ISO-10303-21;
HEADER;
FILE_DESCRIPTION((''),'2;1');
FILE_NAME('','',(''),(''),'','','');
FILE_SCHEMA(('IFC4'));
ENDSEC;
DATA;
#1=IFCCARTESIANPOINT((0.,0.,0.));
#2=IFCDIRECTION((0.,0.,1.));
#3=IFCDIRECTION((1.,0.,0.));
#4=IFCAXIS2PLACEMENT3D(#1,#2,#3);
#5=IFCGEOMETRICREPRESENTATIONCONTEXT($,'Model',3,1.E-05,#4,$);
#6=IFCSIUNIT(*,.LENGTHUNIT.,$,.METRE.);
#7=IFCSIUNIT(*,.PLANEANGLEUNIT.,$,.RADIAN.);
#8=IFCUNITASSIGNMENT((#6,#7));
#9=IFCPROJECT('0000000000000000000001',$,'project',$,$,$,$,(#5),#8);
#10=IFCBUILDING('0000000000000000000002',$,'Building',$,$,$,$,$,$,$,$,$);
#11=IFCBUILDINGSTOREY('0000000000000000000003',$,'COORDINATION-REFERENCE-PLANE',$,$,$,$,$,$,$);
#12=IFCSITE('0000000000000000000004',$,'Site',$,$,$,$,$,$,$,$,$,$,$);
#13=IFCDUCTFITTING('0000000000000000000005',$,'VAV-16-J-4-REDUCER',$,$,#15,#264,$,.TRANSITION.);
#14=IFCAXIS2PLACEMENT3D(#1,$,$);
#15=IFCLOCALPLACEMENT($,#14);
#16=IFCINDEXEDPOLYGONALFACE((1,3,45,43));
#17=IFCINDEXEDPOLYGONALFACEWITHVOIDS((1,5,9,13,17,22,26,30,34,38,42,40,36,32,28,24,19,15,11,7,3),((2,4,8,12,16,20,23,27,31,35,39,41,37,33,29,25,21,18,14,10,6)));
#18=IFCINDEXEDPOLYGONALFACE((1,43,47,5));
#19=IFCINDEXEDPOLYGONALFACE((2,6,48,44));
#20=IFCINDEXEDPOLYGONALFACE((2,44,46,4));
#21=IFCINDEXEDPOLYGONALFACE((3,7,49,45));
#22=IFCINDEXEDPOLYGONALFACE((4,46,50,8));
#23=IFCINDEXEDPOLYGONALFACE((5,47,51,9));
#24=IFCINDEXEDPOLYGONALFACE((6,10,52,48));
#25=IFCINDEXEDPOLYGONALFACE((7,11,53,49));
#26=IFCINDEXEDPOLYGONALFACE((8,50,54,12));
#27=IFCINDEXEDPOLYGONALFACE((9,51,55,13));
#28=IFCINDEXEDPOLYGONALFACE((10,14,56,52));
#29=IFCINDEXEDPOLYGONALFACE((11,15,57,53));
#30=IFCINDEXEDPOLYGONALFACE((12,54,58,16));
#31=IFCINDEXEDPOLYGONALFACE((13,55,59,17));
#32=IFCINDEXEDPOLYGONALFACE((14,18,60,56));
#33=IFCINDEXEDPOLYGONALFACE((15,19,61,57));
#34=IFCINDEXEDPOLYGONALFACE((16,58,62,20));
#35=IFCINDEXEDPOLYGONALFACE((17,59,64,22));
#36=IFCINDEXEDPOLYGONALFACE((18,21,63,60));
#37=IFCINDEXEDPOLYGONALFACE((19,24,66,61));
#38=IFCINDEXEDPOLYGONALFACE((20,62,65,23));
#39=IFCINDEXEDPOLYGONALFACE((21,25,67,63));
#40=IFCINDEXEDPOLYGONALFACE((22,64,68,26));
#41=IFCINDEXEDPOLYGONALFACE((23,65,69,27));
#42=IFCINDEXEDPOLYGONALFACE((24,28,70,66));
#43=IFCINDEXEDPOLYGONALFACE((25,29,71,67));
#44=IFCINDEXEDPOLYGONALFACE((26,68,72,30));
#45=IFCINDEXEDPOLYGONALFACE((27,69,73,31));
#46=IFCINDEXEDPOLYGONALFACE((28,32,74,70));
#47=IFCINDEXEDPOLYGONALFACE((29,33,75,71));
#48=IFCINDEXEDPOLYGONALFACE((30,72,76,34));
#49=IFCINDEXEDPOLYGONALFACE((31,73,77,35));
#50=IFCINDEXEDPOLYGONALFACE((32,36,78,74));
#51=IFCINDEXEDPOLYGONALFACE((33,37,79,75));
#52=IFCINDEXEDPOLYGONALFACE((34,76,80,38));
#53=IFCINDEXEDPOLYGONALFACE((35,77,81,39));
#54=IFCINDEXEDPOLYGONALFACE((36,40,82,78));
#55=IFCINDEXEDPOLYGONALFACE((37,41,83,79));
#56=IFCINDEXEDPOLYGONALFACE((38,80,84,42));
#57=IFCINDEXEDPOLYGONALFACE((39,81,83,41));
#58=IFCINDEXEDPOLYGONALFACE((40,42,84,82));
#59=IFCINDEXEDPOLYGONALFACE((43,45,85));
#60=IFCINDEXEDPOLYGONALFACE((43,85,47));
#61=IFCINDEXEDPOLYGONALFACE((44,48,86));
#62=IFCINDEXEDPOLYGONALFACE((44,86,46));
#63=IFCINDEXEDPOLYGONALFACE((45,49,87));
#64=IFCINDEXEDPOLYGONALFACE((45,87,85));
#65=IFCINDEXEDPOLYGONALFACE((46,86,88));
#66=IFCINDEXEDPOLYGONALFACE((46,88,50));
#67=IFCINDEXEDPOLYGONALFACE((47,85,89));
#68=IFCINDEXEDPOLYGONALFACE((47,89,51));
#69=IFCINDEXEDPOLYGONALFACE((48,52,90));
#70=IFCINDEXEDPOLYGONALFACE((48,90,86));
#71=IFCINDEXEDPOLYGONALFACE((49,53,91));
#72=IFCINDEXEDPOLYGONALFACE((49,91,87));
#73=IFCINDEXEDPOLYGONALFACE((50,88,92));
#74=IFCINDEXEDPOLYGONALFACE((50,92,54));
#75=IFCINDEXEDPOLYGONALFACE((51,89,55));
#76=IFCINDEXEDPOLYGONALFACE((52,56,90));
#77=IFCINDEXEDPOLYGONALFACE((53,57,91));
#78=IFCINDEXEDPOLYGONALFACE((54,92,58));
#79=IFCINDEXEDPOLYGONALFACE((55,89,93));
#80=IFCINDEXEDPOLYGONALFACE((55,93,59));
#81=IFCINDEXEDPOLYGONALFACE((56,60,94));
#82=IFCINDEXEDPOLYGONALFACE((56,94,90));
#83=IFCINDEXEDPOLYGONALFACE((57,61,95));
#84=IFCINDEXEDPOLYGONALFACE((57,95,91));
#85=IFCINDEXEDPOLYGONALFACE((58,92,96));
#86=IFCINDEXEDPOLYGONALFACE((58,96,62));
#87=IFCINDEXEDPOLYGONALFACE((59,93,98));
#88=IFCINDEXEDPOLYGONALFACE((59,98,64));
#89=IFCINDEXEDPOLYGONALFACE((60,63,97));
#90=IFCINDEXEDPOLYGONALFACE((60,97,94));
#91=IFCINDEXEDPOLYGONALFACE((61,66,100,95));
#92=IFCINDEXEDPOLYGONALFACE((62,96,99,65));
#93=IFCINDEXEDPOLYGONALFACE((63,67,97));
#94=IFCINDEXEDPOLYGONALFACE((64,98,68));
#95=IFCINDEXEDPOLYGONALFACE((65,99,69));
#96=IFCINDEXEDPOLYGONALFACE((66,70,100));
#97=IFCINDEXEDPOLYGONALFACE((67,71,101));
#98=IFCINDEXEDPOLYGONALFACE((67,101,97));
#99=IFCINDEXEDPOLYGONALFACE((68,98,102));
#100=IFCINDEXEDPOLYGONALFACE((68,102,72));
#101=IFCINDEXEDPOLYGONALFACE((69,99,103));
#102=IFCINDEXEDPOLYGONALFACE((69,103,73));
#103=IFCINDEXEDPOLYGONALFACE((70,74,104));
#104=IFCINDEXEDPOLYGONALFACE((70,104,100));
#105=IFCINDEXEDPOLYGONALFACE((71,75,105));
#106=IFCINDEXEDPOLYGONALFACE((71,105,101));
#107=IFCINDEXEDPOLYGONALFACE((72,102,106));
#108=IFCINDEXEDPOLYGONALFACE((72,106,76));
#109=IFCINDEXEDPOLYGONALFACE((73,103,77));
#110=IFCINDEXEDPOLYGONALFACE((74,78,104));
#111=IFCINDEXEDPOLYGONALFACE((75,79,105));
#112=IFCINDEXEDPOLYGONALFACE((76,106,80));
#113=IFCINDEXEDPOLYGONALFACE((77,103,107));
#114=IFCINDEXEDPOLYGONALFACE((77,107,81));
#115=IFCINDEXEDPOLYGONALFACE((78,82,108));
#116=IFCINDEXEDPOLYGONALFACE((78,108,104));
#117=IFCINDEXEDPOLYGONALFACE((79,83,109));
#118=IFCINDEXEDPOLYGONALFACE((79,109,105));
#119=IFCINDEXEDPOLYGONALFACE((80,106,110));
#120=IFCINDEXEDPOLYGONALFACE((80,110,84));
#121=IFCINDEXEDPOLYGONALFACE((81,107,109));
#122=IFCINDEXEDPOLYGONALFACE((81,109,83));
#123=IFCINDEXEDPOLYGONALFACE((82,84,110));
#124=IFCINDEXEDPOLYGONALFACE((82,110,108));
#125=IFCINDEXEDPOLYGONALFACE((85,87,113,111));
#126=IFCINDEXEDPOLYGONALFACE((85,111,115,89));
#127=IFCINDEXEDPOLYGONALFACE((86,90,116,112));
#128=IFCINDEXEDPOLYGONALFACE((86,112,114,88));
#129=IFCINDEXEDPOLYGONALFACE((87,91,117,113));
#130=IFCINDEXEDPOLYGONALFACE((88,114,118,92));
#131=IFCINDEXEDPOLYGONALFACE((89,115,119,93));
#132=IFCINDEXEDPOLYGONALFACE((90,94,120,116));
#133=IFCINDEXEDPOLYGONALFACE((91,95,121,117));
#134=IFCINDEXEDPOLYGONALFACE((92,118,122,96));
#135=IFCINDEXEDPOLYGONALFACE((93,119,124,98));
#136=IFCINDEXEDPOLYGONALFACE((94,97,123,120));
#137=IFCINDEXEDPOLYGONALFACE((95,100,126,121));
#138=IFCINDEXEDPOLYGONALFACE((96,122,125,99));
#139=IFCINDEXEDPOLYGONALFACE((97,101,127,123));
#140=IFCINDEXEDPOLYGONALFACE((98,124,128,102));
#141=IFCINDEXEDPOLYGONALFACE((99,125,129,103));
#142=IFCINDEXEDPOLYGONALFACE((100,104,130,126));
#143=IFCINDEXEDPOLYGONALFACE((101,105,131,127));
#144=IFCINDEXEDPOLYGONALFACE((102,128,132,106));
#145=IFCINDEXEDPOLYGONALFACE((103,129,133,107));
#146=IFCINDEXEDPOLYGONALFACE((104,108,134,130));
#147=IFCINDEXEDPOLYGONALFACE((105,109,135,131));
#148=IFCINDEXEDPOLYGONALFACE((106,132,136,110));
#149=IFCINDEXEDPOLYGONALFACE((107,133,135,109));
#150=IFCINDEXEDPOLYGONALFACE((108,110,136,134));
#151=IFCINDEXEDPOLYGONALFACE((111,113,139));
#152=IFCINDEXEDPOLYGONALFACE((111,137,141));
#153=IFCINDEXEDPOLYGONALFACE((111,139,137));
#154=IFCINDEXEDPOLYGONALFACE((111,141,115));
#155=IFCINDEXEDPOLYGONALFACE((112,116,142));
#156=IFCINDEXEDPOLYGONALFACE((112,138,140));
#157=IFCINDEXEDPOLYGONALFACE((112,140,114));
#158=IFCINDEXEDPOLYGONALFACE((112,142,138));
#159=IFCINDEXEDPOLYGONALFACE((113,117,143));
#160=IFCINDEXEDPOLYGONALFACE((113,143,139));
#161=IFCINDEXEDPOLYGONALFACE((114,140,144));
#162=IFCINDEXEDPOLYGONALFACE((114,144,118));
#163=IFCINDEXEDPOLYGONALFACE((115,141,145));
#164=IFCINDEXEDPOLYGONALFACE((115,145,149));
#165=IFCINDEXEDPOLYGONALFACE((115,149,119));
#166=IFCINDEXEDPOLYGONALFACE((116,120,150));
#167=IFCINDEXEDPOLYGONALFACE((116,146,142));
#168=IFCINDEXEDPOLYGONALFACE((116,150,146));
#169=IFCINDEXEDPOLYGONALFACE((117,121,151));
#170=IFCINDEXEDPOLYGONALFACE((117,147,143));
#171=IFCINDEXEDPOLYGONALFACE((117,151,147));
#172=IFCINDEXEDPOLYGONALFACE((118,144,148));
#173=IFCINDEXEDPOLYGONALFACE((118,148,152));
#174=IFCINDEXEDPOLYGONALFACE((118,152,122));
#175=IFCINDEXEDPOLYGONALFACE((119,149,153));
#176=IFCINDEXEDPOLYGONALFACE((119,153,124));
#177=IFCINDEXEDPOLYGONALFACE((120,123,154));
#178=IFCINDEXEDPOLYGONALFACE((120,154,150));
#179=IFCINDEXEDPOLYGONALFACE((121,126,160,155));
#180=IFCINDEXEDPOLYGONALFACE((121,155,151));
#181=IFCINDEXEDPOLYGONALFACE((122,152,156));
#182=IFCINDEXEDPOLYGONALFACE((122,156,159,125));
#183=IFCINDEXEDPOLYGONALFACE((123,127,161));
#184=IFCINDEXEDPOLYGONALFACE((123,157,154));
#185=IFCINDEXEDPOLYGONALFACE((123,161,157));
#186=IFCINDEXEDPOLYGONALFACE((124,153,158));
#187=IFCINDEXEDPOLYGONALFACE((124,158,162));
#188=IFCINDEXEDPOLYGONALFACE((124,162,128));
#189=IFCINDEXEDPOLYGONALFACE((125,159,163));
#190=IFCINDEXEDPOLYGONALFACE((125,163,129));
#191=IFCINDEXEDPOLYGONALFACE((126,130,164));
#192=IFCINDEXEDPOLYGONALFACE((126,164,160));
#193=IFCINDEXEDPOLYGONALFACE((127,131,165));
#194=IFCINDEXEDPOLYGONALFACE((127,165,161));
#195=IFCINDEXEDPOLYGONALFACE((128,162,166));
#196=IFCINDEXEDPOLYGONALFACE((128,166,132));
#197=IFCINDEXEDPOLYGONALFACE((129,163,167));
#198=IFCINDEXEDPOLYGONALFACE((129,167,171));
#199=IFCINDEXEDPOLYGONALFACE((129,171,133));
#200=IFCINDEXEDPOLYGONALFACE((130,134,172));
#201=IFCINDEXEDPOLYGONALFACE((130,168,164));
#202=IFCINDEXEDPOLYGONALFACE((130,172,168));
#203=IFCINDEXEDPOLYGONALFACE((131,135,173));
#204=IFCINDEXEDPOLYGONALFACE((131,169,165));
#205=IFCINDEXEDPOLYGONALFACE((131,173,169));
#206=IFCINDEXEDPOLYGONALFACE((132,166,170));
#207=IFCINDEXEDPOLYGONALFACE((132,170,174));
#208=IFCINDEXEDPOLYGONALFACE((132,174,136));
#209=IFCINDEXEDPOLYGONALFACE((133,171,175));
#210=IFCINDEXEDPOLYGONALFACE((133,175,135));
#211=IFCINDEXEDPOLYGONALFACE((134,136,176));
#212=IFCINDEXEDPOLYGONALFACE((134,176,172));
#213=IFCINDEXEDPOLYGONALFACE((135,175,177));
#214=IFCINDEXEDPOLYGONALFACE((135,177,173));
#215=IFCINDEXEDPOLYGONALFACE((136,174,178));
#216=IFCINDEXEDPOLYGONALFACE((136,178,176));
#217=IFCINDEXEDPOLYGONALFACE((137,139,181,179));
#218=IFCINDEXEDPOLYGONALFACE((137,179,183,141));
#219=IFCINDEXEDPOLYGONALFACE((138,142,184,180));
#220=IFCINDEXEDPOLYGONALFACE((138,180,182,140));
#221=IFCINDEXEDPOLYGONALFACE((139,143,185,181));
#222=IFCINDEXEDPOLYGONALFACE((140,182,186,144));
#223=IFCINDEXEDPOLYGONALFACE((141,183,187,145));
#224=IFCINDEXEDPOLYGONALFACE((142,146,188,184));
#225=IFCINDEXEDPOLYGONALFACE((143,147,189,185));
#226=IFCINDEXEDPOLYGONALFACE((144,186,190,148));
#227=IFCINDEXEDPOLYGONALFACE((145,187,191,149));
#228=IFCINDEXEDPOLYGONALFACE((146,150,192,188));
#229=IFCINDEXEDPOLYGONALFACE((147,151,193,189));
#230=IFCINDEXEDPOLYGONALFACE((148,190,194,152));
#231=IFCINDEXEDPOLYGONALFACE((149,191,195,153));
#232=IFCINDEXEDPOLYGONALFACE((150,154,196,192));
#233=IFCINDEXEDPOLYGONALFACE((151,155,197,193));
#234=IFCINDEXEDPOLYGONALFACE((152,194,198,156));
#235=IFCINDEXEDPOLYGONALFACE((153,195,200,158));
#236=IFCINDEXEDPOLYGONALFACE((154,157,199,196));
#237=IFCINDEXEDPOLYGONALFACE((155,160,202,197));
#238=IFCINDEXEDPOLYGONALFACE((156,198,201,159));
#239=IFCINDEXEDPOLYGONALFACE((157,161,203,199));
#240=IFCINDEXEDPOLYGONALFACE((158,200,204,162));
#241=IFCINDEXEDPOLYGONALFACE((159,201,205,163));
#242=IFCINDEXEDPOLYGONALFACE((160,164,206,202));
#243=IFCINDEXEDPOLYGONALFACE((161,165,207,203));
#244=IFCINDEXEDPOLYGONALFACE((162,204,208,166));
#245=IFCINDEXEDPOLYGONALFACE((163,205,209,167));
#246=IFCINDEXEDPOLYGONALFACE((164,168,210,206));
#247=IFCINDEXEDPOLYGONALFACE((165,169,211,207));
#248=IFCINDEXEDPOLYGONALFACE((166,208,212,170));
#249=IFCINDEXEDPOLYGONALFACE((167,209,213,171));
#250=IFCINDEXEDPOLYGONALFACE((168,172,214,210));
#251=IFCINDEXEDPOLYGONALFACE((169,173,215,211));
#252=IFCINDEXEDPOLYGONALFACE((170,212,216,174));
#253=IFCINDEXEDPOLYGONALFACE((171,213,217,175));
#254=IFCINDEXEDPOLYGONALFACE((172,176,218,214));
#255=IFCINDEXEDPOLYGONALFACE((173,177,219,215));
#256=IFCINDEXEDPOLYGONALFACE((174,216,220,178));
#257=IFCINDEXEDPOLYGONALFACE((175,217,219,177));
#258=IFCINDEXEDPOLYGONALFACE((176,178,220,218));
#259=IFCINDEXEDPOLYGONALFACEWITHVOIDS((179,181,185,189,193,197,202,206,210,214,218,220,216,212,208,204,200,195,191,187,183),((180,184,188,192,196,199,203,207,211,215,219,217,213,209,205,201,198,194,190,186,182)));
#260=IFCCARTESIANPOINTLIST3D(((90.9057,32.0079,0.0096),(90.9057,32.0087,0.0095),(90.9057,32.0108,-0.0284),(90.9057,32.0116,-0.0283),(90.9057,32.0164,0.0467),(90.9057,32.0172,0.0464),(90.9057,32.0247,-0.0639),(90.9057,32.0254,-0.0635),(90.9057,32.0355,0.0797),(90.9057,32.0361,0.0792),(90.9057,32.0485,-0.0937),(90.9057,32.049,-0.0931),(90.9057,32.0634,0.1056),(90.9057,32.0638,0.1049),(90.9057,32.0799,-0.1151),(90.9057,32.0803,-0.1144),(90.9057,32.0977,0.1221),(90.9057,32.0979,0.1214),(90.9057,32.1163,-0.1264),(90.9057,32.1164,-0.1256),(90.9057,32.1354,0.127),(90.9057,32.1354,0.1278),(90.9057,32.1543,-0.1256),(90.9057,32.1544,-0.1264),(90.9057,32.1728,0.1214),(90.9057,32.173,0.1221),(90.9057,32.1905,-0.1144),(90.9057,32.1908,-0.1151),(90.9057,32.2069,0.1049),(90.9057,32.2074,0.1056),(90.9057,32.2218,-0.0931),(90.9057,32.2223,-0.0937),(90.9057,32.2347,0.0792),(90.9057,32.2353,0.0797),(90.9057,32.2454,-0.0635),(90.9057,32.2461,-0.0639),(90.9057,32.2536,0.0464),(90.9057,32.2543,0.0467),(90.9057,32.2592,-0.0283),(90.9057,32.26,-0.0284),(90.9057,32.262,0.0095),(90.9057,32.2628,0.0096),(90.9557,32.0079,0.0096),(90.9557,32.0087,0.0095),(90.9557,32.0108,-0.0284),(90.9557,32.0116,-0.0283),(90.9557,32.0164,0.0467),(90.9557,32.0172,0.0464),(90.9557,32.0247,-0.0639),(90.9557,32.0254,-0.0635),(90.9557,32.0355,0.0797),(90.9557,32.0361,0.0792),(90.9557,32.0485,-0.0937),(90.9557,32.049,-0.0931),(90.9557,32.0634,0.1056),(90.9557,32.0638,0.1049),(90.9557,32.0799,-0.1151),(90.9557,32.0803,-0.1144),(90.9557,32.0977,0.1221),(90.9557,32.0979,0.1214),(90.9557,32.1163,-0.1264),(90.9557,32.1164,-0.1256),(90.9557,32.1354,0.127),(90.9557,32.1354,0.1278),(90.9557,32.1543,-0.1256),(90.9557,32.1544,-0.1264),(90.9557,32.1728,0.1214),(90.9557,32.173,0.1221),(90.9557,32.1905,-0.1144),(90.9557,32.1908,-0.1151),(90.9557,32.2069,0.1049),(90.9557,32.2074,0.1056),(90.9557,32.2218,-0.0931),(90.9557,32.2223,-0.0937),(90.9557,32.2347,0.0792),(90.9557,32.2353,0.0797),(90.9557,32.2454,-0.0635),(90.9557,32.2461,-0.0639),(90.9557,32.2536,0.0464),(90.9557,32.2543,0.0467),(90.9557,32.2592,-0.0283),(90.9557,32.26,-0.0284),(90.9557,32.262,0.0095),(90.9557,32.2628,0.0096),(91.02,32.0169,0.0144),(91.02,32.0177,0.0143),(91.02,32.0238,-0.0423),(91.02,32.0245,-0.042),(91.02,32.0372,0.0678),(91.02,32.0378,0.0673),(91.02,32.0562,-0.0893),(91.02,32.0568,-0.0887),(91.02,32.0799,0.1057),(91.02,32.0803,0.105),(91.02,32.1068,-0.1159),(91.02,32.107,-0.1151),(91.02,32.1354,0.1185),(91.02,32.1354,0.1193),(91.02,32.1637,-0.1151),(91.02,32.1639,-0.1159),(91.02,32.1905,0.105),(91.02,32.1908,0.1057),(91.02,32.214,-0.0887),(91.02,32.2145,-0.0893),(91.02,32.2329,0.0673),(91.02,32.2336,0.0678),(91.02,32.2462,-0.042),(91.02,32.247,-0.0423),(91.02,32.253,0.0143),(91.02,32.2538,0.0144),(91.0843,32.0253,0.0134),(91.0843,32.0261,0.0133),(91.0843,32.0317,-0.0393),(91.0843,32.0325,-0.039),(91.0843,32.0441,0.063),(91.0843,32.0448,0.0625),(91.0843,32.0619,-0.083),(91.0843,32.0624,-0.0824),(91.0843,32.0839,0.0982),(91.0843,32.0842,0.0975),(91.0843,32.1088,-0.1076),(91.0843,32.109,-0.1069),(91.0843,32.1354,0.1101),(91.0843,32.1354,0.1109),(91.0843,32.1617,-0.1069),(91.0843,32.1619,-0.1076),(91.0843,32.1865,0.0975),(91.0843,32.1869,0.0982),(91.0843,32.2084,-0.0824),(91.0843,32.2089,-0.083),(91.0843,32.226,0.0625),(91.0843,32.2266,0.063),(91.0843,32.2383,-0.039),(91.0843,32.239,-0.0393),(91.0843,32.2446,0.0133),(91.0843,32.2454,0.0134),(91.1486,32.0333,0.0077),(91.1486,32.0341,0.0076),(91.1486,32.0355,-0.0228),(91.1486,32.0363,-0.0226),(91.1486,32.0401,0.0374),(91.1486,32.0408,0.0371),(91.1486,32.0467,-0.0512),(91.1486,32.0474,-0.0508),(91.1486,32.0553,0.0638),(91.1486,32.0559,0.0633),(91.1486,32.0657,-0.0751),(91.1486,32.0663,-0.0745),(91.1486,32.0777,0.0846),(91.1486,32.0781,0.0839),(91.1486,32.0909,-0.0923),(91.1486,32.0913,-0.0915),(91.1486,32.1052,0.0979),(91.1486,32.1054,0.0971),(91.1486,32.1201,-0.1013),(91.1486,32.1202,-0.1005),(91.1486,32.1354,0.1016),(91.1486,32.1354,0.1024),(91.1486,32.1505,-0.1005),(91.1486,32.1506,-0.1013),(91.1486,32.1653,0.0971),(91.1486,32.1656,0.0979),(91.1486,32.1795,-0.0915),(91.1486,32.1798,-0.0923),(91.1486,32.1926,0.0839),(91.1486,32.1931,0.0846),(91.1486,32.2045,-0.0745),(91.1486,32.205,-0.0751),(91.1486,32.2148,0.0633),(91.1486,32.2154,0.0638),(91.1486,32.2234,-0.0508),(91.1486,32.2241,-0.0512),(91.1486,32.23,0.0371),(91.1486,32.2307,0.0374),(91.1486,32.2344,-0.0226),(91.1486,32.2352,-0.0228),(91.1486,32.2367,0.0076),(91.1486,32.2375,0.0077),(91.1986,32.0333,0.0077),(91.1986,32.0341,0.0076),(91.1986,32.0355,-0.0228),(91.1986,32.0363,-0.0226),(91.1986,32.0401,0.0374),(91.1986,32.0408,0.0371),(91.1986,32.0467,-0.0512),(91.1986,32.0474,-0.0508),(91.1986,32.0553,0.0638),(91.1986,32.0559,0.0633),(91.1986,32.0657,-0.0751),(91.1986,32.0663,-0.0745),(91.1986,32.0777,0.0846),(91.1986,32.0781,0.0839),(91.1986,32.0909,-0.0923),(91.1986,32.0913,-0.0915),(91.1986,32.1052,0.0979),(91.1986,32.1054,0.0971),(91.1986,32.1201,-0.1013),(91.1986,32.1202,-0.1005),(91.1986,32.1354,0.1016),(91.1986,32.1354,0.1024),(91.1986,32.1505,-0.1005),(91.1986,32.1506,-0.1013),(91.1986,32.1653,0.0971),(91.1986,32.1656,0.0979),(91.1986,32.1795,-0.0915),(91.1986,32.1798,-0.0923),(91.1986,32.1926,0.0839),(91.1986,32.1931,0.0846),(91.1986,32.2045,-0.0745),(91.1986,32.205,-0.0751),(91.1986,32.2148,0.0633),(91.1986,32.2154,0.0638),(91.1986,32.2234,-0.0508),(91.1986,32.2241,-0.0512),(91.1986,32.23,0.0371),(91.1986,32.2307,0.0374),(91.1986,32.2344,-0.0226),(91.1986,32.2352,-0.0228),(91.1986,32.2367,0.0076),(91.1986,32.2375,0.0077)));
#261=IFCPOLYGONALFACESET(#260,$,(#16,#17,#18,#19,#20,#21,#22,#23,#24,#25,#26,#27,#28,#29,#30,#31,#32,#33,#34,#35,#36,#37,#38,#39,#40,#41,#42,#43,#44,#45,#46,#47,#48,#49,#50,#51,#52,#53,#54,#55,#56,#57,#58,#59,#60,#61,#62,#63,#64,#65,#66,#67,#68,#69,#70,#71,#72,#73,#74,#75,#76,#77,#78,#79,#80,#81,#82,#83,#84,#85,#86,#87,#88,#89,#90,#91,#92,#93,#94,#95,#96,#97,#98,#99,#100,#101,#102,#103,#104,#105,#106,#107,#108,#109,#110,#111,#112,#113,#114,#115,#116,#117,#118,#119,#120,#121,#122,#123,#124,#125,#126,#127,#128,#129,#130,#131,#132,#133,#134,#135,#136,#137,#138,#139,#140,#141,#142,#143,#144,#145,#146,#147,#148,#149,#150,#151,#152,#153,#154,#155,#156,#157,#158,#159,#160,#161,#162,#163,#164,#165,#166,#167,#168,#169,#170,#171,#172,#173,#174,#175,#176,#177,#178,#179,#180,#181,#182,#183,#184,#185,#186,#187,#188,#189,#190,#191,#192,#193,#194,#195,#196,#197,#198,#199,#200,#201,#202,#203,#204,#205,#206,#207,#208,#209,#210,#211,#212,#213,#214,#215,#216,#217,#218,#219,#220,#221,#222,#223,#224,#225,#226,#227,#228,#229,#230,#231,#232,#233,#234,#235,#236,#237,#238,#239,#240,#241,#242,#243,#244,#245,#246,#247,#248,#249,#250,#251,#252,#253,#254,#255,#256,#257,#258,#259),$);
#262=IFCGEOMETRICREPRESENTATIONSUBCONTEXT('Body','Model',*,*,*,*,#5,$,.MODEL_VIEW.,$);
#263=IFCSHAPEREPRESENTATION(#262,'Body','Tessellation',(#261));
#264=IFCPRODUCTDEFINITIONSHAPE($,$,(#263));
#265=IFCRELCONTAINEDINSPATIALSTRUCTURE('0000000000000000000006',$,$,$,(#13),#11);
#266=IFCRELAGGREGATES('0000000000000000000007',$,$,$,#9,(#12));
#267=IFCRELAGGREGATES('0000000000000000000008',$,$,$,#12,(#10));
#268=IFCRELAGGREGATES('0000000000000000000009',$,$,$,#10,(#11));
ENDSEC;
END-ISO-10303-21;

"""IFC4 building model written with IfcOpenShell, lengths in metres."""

from ifc_helpers import new_model, entity, si_unit, frame, origin_with_axes, place, context, subcontext, project, spatial, element, save


model = new_model("IFC4")

# Units and contexts
model_context = context("Model", 3, precision=1e-05, world=origin_with_axes())
body_context_1 = subcontext(model_context, "Body", "Model", "MODEL_VIEW")
ifc_project = project(units=[si_unit("LENGTHUNIT", "METRE"), si_unit("PLANEANGLEUNIT", "RADIAN")], contexts=[model_context])

# Site, building, storey
site = spatial("IfcSite", under=ifc_project, Name="Site")
building = spatial("IfcBuilding", under=site, Name="Building")
storey = spatial("IfcBuildingStorey", under=building, Name="COORDINATION-REFERENCE-PLANE")

# Duct fitting
for number, where, z_axis, x_axis, name in (
    (1, (90.9057, 32.1354, 0.0), (0.0, 1.0, 0.0), (0.0, 0.0, 1.0), "VAV-16-J-4-REDUCER"),
):
    element("IfcDuctFitting", number, at=place(None, frame(where, z_axis=z_axis, x_axis=x_axis)), inside=storey, Name=name, PredefinedType="TRANSITION", context=body_context_1, shape_type="SweptSolid", body=[
        entity("IfcRevolvedAreaSolid", entity("IfcArbitraryClosedProfileDef", "AREA", None, entity("IfcPolyline", [entity("IfcCartesianPoint", [0.1278, 0.0]), entity("IfcCartesianPoint", [0.1278, 0.05]), entity("IfcCartesianPoint", [0.1024, 0.2429]), entity("IfcCartesianPoint", [0.1024, 0.2929]), entity("IfcCartesianPoint", [0.1016, 0.2929]), entity("IfcCartesianPoint", [0.1016, 0.2429]), entity("IfcCartesianPoint", [0.127, 0.05]), entity("IfcCartesianPoint", [0.127, 0.0]), entity("IfcCartesianPoint", [0.1278, 0.0])])), entity("IfcAxis2Placement3D", entity("IfcCartesianPoint", [0.0, 0.0, 0.0])), entity("IfcAxis1Placement", entity("IfcCartesianPoint", [0.0, 0.0, 0.0]), entity("IfcDirection", [0.0, 1.0, 0.0])), 6.283185),
    ])

save(model, "model.ifc")
